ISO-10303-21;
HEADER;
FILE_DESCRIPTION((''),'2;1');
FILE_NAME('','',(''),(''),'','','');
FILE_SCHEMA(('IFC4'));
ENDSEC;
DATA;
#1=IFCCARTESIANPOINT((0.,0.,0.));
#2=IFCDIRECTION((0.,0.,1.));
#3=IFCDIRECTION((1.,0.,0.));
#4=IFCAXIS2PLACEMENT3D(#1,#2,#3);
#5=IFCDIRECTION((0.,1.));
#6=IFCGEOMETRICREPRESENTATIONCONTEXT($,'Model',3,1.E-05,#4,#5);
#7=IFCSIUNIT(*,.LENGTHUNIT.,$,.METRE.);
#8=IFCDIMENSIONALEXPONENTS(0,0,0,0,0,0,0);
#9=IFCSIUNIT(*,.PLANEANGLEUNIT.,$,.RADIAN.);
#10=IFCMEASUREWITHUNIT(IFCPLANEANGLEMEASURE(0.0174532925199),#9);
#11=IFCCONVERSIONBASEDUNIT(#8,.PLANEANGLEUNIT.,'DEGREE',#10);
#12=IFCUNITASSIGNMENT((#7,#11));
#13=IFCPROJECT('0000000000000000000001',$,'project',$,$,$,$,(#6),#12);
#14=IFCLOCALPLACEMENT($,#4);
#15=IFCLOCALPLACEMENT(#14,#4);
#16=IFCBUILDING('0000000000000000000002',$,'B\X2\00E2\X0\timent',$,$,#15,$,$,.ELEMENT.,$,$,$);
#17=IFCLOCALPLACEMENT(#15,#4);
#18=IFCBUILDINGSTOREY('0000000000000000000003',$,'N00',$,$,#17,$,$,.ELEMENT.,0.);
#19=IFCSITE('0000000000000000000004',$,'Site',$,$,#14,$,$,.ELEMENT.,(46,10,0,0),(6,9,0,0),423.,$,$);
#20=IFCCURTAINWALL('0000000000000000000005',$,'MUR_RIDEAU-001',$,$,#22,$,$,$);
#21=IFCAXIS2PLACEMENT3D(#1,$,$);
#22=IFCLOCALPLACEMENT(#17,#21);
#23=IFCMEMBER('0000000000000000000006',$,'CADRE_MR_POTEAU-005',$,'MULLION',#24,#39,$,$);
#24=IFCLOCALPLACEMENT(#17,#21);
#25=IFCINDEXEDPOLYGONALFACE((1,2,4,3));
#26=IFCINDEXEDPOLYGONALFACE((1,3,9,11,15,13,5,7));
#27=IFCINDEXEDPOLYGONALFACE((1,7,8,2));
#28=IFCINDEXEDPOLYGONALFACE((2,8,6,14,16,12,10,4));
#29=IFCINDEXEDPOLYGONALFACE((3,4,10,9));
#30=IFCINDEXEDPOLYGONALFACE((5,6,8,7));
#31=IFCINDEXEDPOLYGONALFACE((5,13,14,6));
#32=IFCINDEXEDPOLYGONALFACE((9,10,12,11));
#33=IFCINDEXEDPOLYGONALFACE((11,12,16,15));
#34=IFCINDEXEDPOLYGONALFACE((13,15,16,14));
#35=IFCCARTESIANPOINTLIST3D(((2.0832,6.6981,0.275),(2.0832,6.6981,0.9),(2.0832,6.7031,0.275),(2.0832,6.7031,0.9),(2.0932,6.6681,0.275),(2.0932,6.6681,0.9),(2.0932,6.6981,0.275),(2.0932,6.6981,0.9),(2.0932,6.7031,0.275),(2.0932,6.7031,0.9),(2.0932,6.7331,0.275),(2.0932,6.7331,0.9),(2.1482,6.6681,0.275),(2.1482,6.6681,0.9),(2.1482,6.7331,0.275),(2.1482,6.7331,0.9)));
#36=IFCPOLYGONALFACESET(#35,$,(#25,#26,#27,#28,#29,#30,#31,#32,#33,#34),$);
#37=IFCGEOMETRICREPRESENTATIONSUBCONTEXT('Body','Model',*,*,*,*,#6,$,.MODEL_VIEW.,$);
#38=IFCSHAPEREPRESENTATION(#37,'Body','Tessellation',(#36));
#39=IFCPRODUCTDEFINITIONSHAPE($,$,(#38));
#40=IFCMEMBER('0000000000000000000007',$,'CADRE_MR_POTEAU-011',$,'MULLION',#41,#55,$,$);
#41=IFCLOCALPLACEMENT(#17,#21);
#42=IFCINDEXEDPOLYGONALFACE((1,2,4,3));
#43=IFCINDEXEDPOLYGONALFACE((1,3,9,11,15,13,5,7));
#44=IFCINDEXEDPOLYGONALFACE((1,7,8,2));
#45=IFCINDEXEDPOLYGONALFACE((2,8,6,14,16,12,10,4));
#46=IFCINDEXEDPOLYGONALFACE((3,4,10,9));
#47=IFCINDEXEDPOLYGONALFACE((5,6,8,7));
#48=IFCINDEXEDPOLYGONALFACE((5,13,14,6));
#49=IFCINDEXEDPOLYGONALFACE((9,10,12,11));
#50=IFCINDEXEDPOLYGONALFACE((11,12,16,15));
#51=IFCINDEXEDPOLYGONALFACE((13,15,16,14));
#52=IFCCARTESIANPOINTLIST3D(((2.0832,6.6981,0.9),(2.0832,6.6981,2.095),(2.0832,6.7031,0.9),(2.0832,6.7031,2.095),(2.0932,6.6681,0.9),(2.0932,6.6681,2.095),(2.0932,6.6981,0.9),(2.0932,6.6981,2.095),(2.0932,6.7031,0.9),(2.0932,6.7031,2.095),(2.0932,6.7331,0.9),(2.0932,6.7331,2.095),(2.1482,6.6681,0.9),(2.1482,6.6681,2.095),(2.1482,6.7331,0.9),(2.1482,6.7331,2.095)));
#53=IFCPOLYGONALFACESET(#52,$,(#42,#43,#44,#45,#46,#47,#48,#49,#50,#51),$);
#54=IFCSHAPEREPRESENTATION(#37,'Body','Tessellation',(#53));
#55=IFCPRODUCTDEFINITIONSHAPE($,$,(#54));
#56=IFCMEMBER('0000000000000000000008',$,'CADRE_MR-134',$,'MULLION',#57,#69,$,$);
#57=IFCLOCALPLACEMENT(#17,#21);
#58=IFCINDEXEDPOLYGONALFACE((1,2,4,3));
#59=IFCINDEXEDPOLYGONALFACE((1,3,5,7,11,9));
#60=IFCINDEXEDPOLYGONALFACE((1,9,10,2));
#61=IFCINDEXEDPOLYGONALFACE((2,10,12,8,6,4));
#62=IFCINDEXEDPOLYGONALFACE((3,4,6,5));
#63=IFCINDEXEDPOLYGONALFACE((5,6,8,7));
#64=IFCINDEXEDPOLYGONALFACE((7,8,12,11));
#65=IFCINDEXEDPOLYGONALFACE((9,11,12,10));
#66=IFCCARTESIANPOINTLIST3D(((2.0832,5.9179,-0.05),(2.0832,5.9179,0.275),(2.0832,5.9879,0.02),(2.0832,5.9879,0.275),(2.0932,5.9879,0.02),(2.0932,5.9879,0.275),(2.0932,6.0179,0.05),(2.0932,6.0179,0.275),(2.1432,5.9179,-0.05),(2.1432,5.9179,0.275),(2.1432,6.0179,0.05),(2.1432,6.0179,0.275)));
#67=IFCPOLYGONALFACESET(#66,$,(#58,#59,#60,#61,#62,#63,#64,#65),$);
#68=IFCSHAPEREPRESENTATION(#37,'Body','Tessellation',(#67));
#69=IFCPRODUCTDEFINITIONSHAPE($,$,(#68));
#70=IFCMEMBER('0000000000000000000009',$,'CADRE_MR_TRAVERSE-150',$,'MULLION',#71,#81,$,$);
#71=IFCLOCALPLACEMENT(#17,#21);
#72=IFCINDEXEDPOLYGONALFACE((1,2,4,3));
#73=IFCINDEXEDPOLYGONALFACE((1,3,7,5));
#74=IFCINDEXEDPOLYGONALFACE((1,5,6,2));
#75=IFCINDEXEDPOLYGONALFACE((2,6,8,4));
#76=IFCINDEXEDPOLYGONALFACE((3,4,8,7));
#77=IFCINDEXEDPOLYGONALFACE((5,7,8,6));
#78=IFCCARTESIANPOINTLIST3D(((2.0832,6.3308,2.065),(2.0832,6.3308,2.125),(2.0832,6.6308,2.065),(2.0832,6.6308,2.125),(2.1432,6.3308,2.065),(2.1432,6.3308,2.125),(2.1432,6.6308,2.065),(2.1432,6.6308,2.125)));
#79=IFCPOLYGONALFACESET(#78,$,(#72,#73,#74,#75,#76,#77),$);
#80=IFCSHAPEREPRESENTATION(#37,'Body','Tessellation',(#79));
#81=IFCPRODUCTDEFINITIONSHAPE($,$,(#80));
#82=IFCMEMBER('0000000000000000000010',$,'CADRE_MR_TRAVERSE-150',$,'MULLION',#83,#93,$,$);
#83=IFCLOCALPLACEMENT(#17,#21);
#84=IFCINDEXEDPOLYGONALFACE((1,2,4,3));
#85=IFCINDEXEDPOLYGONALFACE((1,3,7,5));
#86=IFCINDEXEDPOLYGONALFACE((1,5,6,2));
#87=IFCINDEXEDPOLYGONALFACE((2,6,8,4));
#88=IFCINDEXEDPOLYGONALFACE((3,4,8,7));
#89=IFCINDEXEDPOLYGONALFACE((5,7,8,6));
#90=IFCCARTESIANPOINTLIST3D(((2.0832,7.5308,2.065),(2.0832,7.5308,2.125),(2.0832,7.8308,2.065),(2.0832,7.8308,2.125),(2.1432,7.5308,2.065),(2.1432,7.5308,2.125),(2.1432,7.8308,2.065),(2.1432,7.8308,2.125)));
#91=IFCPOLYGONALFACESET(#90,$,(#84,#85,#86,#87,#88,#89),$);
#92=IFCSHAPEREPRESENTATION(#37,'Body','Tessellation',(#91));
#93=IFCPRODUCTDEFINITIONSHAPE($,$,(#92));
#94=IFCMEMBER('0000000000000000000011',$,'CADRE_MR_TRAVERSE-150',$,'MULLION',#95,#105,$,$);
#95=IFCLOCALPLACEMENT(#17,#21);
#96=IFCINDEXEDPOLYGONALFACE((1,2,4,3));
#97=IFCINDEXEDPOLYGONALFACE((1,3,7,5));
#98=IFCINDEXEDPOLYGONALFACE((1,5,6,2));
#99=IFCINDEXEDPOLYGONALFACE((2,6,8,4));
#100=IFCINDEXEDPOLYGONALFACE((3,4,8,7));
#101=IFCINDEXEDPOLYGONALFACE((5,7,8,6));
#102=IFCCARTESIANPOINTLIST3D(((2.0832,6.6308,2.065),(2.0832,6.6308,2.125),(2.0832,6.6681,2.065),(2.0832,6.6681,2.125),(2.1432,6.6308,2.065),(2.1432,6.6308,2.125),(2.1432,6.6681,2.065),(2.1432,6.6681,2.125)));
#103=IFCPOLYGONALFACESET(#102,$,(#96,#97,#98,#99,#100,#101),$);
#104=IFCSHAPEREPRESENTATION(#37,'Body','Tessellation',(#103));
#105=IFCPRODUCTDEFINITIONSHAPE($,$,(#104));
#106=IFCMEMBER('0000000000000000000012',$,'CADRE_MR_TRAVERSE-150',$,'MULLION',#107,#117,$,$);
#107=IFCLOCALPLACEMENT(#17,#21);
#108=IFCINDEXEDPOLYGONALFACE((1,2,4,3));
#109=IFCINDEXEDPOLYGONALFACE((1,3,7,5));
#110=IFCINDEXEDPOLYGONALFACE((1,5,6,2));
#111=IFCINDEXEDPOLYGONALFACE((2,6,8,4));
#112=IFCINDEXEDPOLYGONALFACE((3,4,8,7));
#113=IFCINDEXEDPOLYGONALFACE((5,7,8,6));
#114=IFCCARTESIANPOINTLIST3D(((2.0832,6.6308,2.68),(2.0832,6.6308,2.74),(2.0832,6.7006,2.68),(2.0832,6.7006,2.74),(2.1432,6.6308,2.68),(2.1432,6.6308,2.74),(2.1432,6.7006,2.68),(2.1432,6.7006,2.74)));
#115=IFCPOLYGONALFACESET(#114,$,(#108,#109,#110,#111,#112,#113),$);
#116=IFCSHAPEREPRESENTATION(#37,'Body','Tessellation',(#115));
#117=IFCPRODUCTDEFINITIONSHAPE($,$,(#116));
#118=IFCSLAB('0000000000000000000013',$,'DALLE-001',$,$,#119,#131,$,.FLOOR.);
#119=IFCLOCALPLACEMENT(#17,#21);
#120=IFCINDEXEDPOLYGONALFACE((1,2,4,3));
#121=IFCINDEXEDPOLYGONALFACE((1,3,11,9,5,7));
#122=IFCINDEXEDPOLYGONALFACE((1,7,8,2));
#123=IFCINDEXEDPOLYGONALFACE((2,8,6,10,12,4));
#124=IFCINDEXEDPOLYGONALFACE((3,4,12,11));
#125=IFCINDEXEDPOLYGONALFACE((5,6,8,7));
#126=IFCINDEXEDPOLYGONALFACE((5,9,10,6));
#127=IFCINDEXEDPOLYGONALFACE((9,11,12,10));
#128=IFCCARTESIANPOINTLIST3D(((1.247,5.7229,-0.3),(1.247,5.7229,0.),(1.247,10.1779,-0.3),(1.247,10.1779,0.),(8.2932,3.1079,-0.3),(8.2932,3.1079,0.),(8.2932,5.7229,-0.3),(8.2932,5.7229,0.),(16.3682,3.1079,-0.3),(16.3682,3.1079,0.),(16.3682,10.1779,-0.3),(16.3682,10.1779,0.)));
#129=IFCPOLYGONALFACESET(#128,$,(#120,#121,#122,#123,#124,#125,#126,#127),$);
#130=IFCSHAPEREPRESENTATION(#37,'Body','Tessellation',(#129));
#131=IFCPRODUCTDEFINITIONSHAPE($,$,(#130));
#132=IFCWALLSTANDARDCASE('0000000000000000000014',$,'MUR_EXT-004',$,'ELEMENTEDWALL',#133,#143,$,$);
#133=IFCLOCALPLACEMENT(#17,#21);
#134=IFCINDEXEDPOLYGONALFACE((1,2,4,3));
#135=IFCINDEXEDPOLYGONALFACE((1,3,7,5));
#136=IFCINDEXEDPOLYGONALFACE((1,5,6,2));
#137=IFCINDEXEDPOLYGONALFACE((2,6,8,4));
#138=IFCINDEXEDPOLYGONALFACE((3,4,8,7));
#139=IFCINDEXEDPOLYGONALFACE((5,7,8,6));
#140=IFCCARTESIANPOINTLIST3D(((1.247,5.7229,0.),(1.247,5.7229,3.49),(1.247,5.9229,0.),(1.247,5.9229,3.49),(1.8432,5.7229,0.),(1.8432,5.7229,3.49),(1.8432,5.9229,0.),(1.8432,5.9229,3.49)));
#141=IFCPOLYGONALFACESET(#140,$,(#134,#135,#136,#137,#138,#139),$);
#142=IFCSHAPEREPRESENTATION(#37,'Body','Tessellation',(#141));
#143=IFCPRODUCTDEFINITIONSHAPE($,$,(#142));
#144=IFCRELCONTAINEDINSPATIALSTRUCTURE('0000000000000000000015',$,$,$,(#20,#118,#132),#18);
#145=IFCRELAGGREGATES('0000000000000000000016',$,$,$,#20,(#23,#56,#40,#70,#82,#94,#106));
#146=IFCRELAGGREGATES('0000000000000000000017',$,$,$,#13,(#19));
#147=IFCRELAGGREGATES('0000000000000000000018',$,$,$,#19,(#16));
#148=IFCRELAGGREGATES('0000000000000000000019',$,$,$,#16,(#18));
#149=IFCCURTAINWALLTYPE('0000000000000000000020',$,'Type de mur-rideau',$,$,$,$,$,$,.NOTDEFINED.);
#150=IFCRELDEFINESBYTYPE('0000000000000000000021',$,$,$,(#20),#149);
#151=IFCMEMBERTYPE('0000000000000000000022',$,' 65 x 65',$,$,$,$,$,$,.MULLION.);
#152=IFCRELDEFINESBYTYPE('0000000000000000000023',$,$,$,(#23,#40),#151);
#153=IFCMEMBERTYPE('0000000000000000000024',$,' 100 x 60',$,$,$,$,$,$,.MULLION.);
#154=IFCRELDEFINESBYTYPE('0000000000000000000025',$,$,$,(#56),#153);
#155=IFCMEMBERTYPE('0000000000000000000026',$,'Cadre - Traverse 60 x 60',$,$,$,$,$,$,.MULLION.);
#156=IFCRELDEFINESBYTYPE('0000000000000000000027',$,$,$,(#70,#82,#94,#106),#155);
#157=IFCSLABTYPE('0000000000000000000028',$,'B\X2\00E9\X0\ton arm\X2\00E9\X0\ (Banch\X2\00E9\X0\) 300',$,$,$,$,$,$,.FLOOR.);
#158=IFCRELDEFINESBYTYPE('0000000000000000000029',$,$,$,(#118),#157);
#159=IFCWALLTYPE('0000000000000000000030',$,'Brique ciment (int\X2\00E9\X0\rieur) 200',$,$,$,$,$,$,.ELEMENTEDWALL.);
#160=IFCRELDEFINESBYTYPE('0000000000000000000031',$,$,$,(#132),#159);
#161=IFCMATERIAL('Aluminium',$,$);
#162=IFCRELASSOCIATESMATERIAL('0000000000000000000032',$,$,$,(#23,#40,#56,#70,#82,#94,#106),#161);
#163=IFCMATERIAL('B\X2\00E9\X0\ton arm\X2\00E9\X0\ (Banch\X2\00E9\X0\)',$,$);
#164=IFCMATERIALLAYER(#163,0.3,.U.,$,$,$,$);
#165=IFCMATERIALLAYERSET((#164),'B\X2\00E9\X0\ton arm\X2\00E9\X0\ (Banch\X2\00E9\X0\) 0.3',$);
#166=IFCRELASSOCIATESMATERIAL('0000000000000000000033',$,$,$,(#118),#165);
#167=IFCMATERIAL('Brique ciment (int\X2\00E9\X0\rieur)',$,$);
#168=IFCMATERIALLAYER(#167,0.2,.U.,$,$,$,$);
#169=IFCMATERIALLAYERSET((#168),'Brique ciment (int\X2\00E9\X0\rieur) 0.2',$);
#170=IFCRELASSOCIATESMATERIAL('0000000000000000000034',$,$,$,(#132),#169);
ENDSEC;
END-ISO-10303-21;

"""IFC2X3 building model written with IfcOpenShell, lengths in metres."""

from ifc_helpers import new_model, entity, si_unit, converted_unit, direction, frame, origin_with_axes, place, context, subcontext, project, spatial, polyline, outline, extrude, clip, halfspace, material, layer, layer_set, layer_usage, type_object, element, aggregate, save


model = new_model("IFC2X3")

# Units and contexts
model_context = context("Model", 3, precision=1e-05, world=origin_with_axes(), true_north=direction((0.0, 1.0)))
body_context = subcontext(model_context, "Body", "Model", "MODEL_VIEW")
ifc_project = project(units=[si_unit("LENGTHUNIT", "METRE"), converted_unit("PLANEANGLEUNIT", "DEGREE", entity("IfcPlaneAngleMeasure", 0.0174532925199), si_unit("PLANEANGLEUNIT", "RADIAN"), dimensions=[0, 0, 0, 0, 0, 0, 0])], contexts=[model_context])

# Site, building, storey
site_placement = place(None, origin_with_axes())
site = spatial("IfcSite", under=ifc_project, at=site_placement, Name="Site", CompositionType="ELEMENT", RefLatitude=(46, 10, 0, 0), RefLongitude=(6, 9, 0, 0), RefElevation=423.0)
building_placement = place(site_placement, origin_with_axes())
building = spatial("IfcBuilding", under=site, at=building_placement, Name="Bâtiment", CompositionType="ELEMENT")
storey_placement = place(building_placement, origin_with_axes())
storey = spatial("IfcBuildingStorey", under=building, at=storey_placement, Name="N00", CompositionType="ELEMENT", Elevation=0.0)

# Curtain wall, members
curtain_wall_type = type_object("IfcCurtainWallType", Name="Type de mur-rideau", PredefinedType="NOTDEFINED")
curtain_wall_placement = place(storey_placement, frame((2.0832, 6.4208, 0.0), z_axis=(0.0, 0.0, 1.0), x_axis=(1.0, 0.0, 0.0)))
curtain_wall = element("IfcCurtainWall", 1, at=curtain_wall_placement, inside=storey, type_object=curtain_wall_type, Name="MUR_RIDEAU-001")
ifc_material_1 = material(Name="Aluminium")
member_type_1 = type_object("IfcMemberType", Name=" 65 x 65", PredefinedType="MULLION")
member_1_placement = place(curtain_wall_placement, frame((0.0, 0.2798, 0.275), z_axis=(0.0, 0.0, 1.0), x_axis=(0.0, 1.0, 0.0)))
member_1 = element("IfcMember", 2, at=member_1_placement, type_object=member_type_1, material=ifc_material_1, Name="CADRE_MR_POTEAU-005", ObjectType="MULLION", context=body_context, shape_type="SweptSolid", body=[
    extrude(outline(polyline([(0.01, -0.0025), (0.01, -0.0325), (0.065, -0.0325), (0.065, 0.0325), (0.01, 0.0325), (0.01, 0.0025), (0.0, 0.0025), (0.0, -0.0025), (0.01, -0.0025)])), frame((0.0, 0.0, 0.0), z_axis=(0.0, 0.0, 1.0), x_axis=(0.0, -1.0, 0.0)), (0.0, 0.0, 1.0), 0.625),
])
member_2_placement = place(curtain_wall_placement, frame((0.0, 0.2798, 0.9), z_axis=(0.0, 0.0, 1.0), x_axis=(0.0, 1.0, 0.0)))
member_2 = element("IfcMember", 3, at=member_2_placement, type_object=member_type_1, material=ifc_material_1, Name="CADRE_MR_POTEAU-011", ObjectType="MULLION", context=body_context, shape_type="SweptSolid", body=[
    extrude(outline(polyline([(0.01, -0.0025), (0.01, -0.0325), (0.065, -0.0325), (0.065, 0.0325), (0.01, 0.0325), (0.01, 0.0025), (0.0, 0.0025), (0.0, -0.0025), (0.01, -0.0025)])), frame((0.0, 0.0, 0.0), z_axis=(0.0, 0.0, 1.0), x_axis=(0.0, -1.0, 0.0)), (0.0, 0.0, 1.0), 1.195),
])
member_type_2 = type_object("IfcMemberType", Name=" 100 x 60", PredefinedType="MULLION")
member_3_placement = place(curtain_wall_placement, frame((0.0, -0.4529, 0.0), z_axis=(0.0, 0.0, 1.0), x_axis=(0.0, 1.0, 0.0)))
member_3 = element("IfcMember", 4, at=member_3_placement, type_object=member_type_2, material=ifc_material_1, Name="CADRE_MR-134", ObjectType="MULLION", context=body_context, shape_type="Clipping", body=[
    clip(extrude(outline(polyline([(0.01, 0.02), (0.0, 0.02), (0.0, -0.05), (0.06, -0.05), (0.06, 0.05), (0.01, 0.05), (0.01, 0.02)])), frame((0.0, 0.0, -0.05), z_axis=(0.0, 0.0, 1.0), x_axis=(0.0, -1.0, 0.0)), (0.0, 0.0, 1.0), 0.325), halfspace(frame((0.0, 0.0, 0.0), z_axis=(-0.707107, 0.0, 0.707107), x_axis=(0.0, -1.0, 0.0)), True)),
])
member_type_3 = type_object("IfcMemberType", Name="Cadre - Traverse 60 x 60", PredefinedType="MULLION")
member_4_placement = place(curtain_wall_placement, frame((0.0, 0.2099, 2.095), z_axis=(0.0, -1.0, 0.0), x_axis=(0.0, 0.0, 1.0)))
member_4 = element("IfcMember", 5, at=member_4_placement, type_object=member_type_3, material=ifc_material_1, Name="CADRE_MR_TRAVERSE-150", ObjectType="MULLION", context=body_context, shape_type="SweptSolid", body=[
    extrude(outline(polyline([(-0.06, -0.03), (0.0, -0.03), (0.0, 0.03), (-0.06, 0.03), (-0.06, -0.03)])), frame((0.0, 0.0, 0.0), z_axis=(0.0, 0.0, 1.0), x_axis=(0.0, 1.0, 0.0)), (0.0, 0.0, 1.0), 0.3),
])
member_5_placement = place(curtain_wall_placement, frame((0.0, 1.4099, 2.095), z_axis=(0.0, -1.0, 0.0), x_axis=(0.0, 0.0, 1.0)))
member_5 = element("IfcMember", 6, at=member_5_placement, type_object=member_type_3, material=ifc_material_1, Name="CADRE_MR_TRAVERSE-150", ObjectType="MULLION", context=body_context, shape_type="SweptSolid", body=[
    extrude(outline(polyline([(-0.06, -0.03), (0.0, -0.03), (0.0, 0.03), (-0.06, 0.03), (-0.06, -0.03)])), frame((0.0, 0.0, 0.0), z_axis=(0.0, 0.0, 1.0), x_axis=(0.0, 1.0, 0.0)), (0.0, 0.0, 1.0), 0.3),
])
member_6_placement = place(curtain_wall_placement, frame((0.0, 0.2798, 2.095), z_axis=(0.0, -1.0, 0.0), x_axis=(0.0, 0.0, 1.0)))
member_6 = element("IfcMember", 7, at=member_6_placement, type_object=member_type_3, material=ifc_material_1, Name="CADRE_MR_TRAVERSE-150", ObjectType="MULLION", context=body_context, shape_type="SweptSolid", body=[
    extrude(outline(polyline([(-0.06, -0.03), (0.0, -0.03), (0.0, 0.03), (-0.06, 0.03), (-0.06, -0.03)])), frame((0.0, 0.0, 0.0325), z_axis=(0.0, 0.0, 1.0), x_axis=(0.0, 1.0, 0.0)), (0.0, 0.0, 1.0), 0.0374),
])
member_7_placement = place(curtain_wall_placement, frame((0.0, 0.2798, 2.71), z_axis=(0.0, -1.0, 0.0), x_axis=(0.0, 0.0, 1.0)))
member_7 = element("IfcMember", 8, at=member_7_placement, type_object=member_type_3, material=ifc_material_1, Name="CADRE_MR_TRAVERSE-150", ObjectType="MULLION", context=body_context, shape_type="SweptSolid", body=[
    extrude(outline(polyline([(-0.06, -0.03), (0.0, -0.03), (0.0, 0.03), (-0.06, 0.03), (-0.06, -0.03)])), frame((0.0, 0.0, 0.0), z_axis=(0.0, 0.0, 1.0), x_axis=(0.0, 1.0, 0.0)), (0.0, 0.0, 1.0), 0.0699),
])
aggregate(curtain_wall, [member_1, member_3, member_2, member_4, member_5, member_6, member_7])

# Slab
ifc_material_2 = material(Name="Béton armé (Banché)")
ifc_layer_1 = layer(ifc_material_2, 0.3, ventilated="UNKNOWN")
ifc_layer_set_1 = layer_set([ifc_layer_1], Name="Béton armé (Banché) 0.3")
ifc_layer_usage_1 = layer_usage(ifc_layer_set_1, "AXIS3", "NEGATIVE", 0.3)
slab_type = type_object("IfcSlabType", Name="Béton armé (Banché) 300", PredefinedType="FLOOR")
slab_placement = place(storey_placement, frame((1.247, 5.7229, 0.0), z_axis=(0.0, 0.0, 1.0), x_axis=(1.0, 0.0, 0.0)))
element("IfcSlab", 9, at=slab_placement, inside=storey, type_object=slab_type, material=ifc_layer_usage_1, Name="DALLE-001", PredefinedType="FLOOR", context=body_context, shape_type="SweptSolid", body=[
    extrude(outline(polyline([(0.0, 0.0), (7.0461, 0.0), (7.0461, -2.615), (15.1212, -2.615), (15.1212, 4.455), (0.0, 4.455), (0.0, 0.0)])), frame((0.0, 0.0, -0.3), z_axis=(0.0, 0.0, 1.0), x_axis=(1.0, 0.0, 0.0)), (0.0, 0.0, 1.0), 0.3),
])

# Wall
ifc_material_3 = material(Name="Brique ciment (intérieur)")
ifc_layer_2 = layer(ifc_material_3, 0.2, ventilated="UNKNOWN")
ifc_layer_set_2 = layer_set([ifc_layer_2], Name="Brique ciment (intérieur) 0.2")
ifc_layer_usage_2 = layer_usage(ifc_layer_set_2, "AXIS2", "NEGATIVE", 0.2)
wall_type = type_object("IfcWallType", Name="Brique ciment (intérieur) 200", PredefinedType="ELEMENTEDWALL")
wall_placement = place(storey_placement, frame((1.8432, 5.9229, 0.0), z_axis=(0.0, 0.0, 1.0), x_axis=(-1.0, 0.0, 0.0)))
element("IfcWallStandardCase", 10, at=wall_placement, inside=storey, type_object=wall_type, material=ifc_layer_usage_2, Name="MUR_EXT-004", ObjectType="ELEMENTEDWALL", context=body_context, shape_type="SweptSolid", body=[
    extrude(outline(polyline([(0.0, 0.0), (0.5961, 0.0), (0.5961, 0.2), (0.0, 0.2), (0.0, 0.0)])), origin_with_axes(), (0.0, 0.0, 1.0), 3.49),
])

save(model, "model.ifc")
